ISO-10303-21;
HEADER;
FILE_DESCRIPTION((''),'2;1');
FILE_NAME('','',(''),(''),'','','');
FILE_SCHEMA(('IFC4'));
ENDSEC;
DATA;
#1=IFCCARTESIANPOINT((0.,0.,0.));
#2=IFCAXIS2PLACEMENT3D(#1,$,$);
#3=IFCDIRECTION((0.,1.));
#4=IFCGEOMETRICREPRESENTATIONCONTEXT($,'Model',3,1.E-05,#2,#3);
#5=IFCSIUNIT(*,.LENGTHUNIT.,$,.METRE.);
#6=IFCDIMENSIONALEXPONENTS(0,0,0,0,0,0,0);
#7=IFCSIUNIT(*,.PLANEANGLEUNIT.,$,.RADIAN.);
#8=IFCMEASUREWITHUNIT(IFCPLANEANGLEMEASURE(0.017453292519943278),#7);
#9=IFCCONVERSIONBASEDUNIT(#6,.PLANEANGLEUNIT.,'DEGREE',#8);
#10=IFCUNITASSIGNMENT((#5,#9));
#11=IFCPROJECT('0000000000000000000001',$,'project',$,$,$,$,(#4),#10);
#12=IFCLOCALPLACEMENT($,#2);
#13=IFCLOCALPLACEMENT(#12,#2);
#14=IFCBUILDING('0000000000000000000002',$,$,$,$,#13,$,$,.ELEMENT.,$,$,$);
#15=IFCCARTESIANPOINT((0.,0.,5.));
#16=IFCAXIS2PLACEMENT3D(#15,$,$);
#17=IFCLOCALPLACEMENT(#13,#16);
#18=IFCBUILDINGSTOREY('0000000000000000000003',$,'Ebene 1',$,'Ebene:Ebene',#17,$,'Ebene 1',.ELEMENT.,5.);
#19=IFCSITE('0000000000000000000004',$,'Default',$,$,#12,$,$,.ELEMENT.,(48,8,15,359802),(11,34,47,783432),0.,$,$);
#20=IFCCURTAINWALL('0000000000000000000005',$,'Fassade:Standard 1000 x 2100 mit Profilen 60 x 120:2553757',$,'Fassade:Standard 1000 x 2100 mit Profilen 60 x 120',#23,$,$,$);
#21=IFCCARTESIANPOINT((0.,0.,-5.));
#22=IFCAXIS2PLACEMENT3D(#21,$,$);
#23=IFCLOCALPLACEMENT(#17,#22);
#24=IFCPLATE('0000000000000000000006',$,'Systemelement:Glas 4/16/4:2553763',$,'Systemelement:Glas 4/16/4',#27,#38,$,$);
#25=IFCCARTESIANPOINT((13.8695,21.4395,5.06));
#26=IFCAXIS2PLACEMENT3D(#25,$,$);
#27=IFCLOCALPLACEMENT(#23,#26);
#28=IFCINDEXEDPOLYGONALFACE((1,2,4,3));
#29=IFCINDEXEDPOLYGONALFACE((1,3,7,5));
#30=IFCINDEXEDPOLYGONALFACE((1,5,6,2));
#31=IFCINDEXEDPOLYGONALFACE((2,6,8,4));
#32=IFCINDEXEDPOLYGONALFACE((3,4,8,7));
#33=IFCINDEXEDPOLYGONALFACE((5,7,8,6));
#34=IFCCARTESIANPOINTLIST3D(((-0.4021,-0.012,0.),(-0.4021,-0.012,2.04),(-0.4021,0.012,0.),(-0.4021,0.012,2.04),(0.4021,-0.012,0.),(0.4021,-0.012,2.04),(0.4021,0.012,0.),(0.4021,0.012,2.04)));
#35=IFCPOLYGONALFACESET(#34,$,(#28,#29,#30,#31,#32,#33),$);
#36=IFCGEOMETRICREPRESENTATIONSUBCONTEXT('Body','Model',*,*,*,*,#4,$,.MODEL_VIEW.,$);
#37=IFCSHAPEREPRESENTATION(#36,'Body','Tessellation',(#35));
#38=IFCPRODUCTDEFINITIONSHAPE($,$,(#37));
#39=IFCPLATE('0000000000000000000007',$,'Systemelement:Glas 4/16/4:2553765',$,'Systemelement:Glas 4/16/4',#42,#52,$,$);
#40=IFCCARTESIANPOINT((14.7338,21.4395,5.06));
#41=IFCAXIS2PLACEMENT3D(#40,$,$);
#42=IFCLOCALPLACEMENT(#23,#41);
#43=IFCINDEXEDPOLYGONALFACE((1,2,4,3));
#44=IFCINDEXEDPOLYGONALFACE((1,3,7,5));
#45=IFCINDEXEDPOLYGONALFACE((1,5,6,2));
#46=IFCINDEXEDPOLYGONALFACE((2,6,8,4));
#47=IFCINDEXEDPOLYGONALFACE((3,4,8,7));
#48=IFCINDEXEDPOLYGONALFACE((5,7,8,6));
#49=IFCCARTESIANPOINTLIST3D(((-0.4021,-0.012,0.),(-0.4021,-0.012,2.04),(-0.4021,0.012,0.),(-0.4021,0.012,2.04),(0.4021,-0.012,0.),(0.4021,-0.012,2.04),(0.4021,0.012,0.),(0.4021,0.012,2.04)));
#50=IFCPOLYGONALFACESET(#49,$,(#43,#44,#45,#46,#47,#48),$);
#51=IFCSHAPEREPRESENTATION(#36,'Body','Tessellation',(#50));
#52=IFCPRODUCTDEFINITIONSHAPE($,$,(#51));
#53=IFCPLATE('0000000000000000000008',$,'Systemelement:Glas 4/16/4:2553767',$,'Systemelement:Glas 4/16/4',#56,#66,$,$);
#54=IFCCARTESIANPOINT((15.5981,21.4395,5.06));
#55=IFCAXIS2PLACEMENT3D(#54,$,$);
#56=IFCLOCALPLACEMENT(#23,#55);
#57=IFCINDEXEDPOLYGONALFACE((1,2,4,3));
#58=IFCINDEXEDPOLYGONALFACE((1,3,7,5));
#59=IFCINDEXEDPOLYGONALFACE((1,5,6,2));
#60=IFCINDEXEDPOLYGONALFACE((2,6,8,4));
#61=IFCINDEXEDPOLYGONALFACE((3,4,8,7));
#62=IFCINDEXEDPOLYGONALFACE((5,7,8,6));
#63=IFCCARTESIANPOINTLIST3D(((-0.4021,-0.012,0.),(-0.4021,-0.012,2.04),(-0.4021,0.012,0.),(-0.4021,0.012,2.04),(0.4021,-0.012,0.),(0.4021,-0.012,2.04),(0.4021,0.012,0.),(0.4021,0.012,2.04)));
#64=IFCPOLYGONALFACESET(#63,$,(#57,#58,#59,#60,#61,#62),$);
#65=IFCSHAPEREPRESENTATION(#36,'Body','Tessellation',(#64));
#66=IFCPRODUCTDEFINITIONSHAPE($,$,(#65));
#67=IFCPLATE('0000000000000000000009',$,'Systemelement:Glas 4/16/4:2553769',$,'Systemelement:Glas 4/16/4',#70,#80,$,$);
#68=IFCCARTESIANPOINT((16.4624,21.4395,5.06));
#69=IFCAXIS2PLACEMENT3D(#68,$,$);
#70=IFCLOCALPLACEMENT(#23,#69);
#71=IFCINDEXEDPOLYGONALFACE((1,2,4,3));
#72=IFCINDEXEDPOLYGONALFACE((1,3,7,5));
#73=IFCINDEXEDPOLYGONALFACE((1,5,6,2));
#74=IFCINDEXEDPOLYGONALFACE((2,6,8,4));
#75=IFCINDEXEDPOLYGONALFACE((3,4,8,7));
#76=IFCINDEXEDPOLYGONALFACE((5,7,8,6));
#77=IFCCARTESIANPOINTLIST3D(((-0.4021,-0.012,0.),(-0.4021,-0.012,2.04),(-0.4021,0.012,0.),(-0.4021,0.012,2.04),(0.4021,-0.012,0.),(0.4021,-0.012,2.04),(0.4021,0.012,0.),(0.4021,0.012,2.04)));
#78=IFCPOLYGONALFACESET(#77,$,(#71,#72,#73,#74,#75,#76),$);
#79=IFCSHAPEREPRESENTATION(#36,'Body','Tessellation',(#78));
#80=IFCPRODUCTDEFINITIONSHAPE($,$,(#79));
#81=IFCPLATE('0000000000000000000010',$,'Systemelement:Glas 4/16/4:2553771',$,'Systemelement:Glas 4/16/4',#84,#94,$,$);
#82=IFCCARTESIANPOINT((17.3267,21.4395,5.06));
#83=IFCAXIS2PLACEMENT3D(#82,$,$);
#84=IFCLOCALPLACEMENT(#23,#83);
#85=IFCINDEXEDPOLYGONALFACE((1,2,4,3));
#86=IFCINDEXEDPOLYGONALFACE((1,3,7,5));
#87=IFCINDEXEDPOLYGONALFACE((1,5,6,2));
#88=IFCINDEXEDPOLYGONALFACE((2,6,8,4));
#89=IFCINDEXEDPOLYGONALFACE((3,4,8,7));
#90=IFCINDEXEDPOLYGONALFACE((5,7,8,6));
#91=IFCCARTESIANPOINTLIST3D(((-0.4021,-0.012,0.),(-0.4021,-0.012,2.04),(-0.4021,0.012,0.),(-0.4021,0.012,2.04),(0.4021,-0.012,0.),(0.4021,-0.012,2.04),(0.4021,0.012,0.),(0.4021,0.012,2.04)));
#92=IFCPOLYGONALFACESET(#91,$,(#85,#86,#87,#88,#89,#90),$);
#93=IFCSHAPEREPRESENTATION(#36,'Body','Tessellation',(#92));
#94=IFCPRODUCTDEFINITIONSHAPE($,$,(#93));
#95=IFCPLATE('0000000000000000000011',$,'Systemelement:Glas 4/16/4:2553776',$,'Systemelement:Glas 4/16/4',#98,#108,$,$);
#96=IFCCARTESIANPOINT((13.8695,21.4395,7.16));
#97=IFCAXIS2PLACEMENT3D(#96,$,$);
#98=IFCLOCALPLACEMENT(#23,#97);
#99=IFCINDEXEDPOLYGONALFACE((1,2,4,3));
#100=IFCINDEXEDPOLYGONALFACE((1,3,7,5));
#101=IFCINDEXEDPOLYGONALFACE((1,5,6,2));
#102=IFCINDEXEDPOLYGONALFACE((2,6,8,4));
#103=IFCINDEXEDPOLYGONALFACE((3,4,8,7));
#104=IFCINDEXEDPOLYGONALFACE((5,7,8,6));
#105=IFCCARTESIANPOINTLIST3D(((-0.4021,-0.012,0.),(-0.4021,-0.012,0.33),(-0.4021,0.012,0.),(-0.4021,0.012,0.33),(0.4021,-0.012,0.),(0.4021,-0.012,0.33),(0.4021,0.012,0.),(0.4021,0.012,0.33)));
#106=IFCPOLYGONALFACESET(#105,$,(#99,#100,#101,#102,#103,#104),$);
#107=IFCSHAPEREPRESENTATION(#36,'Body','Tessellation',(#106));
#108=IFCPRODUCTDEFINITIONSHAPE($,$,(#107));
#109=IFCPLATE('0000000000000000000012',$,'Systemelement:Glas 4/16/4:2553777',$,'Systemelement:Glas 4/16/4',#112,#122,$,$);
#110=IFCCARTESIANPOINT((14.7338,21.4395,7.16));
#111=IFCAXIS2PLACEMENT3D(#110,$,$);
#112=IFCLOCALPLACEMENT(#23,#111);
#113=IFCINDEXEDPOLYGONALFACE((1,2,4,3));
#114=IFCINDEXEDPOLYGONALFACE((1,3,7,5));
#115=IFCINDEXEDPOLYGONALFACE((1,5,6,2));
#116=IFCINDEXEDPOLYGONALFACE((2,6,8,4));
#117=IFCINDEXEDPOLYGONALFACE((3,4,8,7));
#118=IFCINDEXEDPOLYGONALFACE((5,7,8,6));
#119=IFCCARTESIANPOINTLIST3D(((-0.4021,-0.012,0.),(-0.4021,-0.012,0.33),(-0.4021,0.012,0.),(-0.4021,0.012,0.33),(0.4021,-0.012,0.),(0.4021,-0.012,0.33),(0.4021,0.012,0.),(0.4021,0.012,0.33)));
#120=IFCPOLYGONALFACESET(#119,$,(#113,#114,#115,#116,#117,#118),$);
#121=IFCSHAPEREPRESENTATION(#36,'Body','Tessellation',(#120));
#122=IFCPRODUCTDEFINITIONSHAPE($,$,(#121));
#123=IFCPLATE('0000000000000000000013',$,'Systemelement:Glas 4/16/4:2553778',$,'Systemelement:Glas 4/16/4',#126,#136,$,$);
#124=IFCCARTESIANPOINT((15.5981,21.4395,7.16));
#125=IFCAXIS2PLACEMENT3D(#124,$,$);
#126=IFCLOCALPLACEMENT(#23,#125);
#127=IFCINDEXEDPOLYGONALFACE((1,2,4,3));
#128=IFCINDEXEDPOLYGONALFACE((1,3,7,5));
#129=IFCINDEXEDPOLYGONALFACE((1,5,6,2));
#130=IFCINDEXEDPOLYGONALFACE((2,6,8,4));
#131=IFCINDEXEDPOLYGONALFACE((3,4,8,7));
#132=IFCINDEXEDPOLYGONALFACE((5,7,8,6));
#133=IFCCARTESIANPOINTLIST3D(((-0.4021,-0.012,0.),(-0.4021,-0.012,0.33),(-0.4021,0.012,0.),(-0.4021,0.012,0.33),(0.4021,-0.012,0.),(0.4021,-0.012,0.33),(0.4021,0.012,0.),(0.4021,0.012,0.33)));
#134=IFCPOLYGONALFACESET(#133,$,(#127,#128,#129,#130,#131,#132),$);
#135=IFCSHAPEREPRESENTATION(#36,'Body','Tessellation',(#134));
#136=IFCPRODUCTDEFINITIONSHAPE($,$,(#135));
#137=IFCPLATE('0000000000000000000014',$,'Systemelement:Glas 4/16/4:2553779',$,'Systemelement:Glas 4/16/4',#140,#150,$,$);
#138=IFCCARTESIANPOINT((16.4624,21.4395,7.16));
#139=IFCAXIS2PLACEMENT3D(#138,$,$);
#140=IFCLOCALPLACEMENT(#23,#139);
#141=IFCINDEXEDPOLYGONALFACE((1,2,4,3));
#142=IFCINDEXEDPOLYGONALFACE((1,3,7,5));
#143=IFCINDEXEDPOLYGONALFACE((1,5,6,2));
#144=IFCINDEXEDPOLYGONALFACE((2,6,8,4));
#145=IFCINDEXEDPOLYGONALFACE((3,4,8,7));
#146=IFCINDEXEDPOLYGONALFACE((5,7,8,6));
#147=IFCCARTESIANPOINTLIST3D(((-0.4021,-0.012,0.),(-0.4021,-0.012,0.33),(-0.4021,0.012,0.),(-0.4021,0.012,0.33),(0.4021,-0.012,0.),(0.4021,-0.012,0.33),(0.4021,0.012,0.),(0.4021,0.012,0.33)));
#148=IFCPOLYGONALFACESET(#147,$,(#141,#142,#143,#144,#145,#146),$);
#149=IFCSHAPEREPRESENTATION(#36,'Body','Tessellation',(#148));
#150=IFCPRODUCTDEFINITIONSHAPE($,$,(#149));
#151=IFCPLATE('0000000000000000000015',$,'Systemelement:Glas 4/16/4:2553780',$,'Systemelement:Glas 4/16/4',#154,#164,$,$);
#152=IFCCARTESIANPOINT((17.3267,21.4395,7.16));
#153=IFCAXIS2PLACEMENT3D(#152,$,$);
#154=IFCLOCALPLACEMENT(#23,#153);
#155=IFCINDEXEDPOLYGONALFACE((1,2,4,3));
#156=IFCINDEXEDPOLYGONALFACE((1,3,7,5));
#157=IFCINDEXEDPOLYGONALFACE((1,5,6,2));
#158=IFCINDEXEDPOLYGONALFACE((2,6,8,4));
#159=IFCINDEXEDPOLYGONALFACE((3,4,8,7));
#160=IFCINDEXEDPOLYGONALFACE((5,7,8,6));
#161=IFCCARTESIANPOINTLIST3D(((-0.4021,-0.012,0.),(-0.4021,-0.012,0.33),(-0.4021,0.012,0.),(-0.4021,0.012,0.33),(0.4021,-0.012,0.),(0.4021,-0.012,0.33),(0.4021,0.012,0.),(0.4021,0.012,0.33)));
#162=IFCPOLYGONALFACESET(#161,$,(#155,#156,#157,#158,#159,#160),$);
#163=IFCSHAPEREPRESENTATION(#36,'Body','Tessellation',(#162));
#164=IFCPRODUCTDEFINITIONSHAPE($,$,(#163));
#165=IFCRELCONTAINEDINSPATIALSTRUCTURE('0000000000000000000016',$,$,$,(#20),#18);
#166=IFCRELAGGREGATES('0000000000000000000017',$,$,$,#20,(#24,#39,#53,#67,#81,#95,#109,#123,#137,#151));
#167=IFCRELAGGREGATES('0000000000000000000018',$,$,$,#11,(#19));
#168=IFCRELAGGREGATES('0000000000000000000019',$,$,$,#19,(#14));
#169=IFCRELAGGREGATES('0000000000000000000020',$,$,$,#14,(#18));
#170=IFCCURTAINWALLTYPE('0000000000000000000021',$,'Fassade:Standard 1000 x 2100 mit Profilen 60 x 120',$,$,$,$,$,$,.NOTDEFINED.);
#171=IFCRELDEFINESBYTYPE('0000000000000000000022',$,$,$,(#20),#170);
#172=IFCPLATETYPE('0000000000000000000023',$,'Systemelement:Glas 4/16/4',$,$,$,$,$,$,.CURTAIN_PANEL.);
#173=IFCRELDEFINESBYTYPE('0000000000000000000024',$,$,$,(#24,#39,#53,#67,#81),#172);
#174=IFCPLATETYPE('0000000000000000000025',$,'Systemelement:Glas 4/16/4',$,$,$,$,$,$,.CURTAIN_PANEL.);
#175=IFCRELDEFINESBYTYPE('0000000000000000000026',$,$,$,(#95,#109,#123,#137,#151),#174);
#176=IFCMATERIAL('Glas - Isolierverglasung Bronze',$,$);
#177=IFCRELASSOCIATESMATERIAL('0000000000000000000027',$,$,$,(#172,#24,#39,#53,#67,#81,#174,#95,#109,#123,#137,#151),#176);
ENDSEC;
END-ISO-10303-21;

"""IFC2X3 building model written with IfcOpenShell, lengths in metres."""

from ifc_helpers import new_model, entity, si_unit, converted_unit, direction, frame, origin, origin_2d_with_axis, place, context, subcontext, project, spatial, rectangle, extrude, source, transform, mapped, material, type_object, type_shapes, element, aggregate, save


model = new_model("IFC2X3")

# Units and contexts
model_context = context("Model", 3, precision=1e-05, world=origin(), true_north=direction((0.0, 1.0)))
body_context = subcontext(model_context, "Body", "Model", "MODEL_VIEW")
ifc_project = project(units=[si_unit("LENGTHUNIT", "METRE"), converted_unit("PLANEANGLEUNIT", "DEGREE", entity("IfcPlaneAngleMeasure", 0.017453292519943278), si_unit("PLANEANGLEUNIT", "RADIAN"), dimensions=[0, 0, 0, 0, 0, 0, 0])], contexts=[model_context])

# Site, building, storey
site_placement = place(None, origin())
site = spatial("IfcSite", under=ifc_project, at=site_placement, Name="Default", CompositionType="ELEMENT", RefLatitude=(48, 8, 15, 359802), RefLongitude=(11, 34, 47, 783432), RefElevation=0.0)
building_placement = place(site_placement, origin())
building = spatial("IfcBuilding", under=site, at=building_placement, CompositionType="ELEMENT")
storey_placement = place(building_placement, frame((0.0, 0.0, 5.0)))
storey = spatial("IfcBuildingStorey", under=building, at=storey_placement, Name="Ebene 1", ObjectType="Ebene:Ebene", LongName="Ebene 1", CompositionType="ELEMENT", Elevation=5.0)

# Curtain wall, plates
curtain_wall_type = type_object("IfcCurtainWallType", Name="Fassade:Standard 1000 x 2100 mit Profilen 60 x 120", PredefinedType="NOTDEFINED")
curtain_wall_placement = place(storey_placement, frame((0.0, 0.0, -5.0)))
curtain_wall = element("IfcCurtainWall", 1, at=curtain_wall_placement, inside=storey, type_object=curtain_wall_type, Name="Fassade:Standard 1000 x 2100 mit Profilen 60 x 120:2553757", ObjectType="Fassade:Standard 1000 x 2100 mit Profilen 60 x 120")
ifc_material_1 = material(Name="Glas - Isolierverglasung Bronze")
plate_type_1 = type_object("IfcPlateType", Name="Systemelement:Glas 4/16/4", PredefinedType="CURTAIN_PANEL", material=ifc_material_1)
shared_shape_1 = source(origin(), body_context, "Body", "SweptSolid", [
    extrude(rectangle(XDim=0.024, YDim=0.8043, at=origin_2d_with_axis()), frame((0.0, 0.0, 0.0), z_axis=(0.0, 0.0, 1.0), x_axis=(0.0, 1.0, 0.0)), (0.0, 0.0, 1.0), 2.04),
])
type_shapes(plate_type_1, [shared_shape_1])
plate_1_placement = place(curtain_wall_placement, frame((13.8695, 21.4395, 5.06)))
plate_1 = element("IfcPlate", 2, at=plate_1_placement, type_object=plate_type_1, material=ifc_material_1, Name="Systemelement:Glas 4/16/4:2553763", ObjectType="Systemelement:Glas 4/16/4", context=body_context, shape_type="MappedRepresentation", body=[
    mapped(shared_shape_1, transform((0.0, 0.0, 0.0), scale=1.0)),
])
plate_2_placement = place(curtain_wall_placement, frame((14.7338, 21.4395, 5.06)))
plate_2 = element("IfcPlate", 3, at=plate_2_placement, type_object=plate_type_1, material=ifc_material_1, Name="Systemelement:Glas 4/16/4:2553765", ObjectType="Systemelement:Glas 4/16/4", context=body_context, shape_type="MappedRepresentation", body=[
    mapped(shared_shape_1, transform((0.0, 0.0, 0.0), scale=1.0)),
])
plate_3_placement = place(curtain_wall_placement, frame((15.5981, 21.4395, 5.06)))
plate_3 = element("IfcPlate", 4, at=plate_3_placement, type_object=plate_type_1, material=ifc_material_1, Name="Systemelement:Glas 4/16/4:2553767", ObjectType="Systemelement:Glas 4/16/4", context=body_context, shape_type="MappedRepresentation", body=[
    mapped(shared_shape_1, transform((0.0, 0.0, 0.0), scale=1.0)),
])
plate_4_placement = place(curtain_wall_placement, frame((16.4624, 21.4395, 5.06)))
plate_4 = element("IfcPlate", 5, at=plate_4_placement, type_object=plate_type_1, material=ifc_material_1, Name="Systemelement:Glas 4/16/4:2553769", ObjectType="Systemelement:Glas 4/16/4", context=body_context, shape_type="MappedRepresentation", body=[
    mapped(shared_shape_1, transform((0.0, 0.0, 0.0), scale=1.0)),
])
plate_5_placement = place(curtain_wall_placement, frame((17.3267, 21.4395, 5.06)))
plate_5 = element("IfcPlate", 6, at=plate_5_placement, type_object=plate_type_1, material=ifc_material_1, Name="Systemelement:Glas 4/16/4:2553771", ObjectType="Systemelement:Glas 4/16/4", context=body_context, shape_type="MappedRepresentation", body=[
    mapped(shared_shape_1, transform((0.0, 0.0, 0.0), scale=1.0)),
])
plate_type_2 = type_object("IfcPlateType", Name="Systemelement:Glas 4/16/4", PredefinedType="CURTAIN_PANEL", material=ifc_material_1)
shared_shape_2 = source(origin(), body_context, "Body", "SweptSolid", [
    extrude(rectangle(XDim=0.024, YDim=0.8043, at=origin_2d_with_axis()), frame((0.0, 0.0, 0.0), z_axis=(0.0, 0.0, 1.0), x_axis=(0.0, 1.0, 0.0)), (0.0, 0.0, 1.0), 0.33),
])
type_shapes(plate_type_2, [shared_shape_2])
plate_6_placement = place(curtain_wall_placement, frame((13.8695, 21.4395, 7.16)))
plate_6 = element("IfcPlate", 7, at=plate_6_placement, type_object=plate_type_2, material=ifc_material_1, Name="Systemelement:Glas 4/16/4:2553776", ObjectType="Systemelement:Glas 4/16/4", context=body_context, shape_type="MappedRepresentation", body=[
    mapped(shared_shape_2, transform((0.0, 0.0, 0.0), scale=1.0)),
])
plate_7_placement = place(curtain_wall_placement, frame((14.7338, 21.4395, 7.16)))
plate_7 = element("IfcPlate", 8, at=plate_7_placement, type_object=plate_type_2, material=ifc_material_1, Name="Systemelement:Glas 4/16/4:2553777", ObjectType="Systemelement:Glas 4/16/4", context=body_context, shape_type="MappedRepresentation", body=[
    mapped(shared_shape_2, transform((0.0, 0.0, 0.0), scale=1.0)),
])
plate_8_placement = place(curtain_wall_placement, frame((15.5981, 21.4395, 7.16)))
plate_8 = element("IfcPlate", 9, at=plate_8_placement, type_object=plate_type_2, material=ifc_material_1, Name="Systemelement:Glas 4/16/4:2553778", ObjectType="Systemelement:Glas 4/16/4", context=body_context, shape_type="MappedRepresentation", body=[
    mapped(shared_shape_2, transform((0.0, 0.0, 0.0), scale=1.0)),
])
plate_9_placement = place(curtain_wall_placement, frame((16.4624, 21.4395, 7.16)))
plate_9 = element("IfcPlate", 10, at=plate_9_placement, type_object=plate_type_2, material=ifc_material_1, Name="Systemelement:Glas 4/16/4:2553779", ObjectType="Systemelement:Glas 4/16/4", context=body_context, shape_type="MappedRepresentation", body=[
    mapped(shared_shape_2, transform((0.0, 0.0, 0.0), scale=1.0)),
])
plate_10_placement = place(curtain_wall_placement, frame((17.3267, 21.4395, 7.16)))
plate_10 = element("IfcPlate", 11, at=plate_10_placement, type_object=plate_type_2, material=ifc_material_1, Name="Systemelement:Glas 4/16/4:2553780", ObjectType="Systemelement:Glas 4/16/4", context=body_context, shape_type="MappedRepresentation", body=[
    mapped(shared_shape_2, transform((0.0, 0.0, 0.0), scale=1.0)),
])
aggregate(curtain_wall, [plate_1, plate_2, plate_3, plate_4, plate_5, plate_6, plate_7, plate_8, plate_9, plate_10])

save(model, "model.ifc")
